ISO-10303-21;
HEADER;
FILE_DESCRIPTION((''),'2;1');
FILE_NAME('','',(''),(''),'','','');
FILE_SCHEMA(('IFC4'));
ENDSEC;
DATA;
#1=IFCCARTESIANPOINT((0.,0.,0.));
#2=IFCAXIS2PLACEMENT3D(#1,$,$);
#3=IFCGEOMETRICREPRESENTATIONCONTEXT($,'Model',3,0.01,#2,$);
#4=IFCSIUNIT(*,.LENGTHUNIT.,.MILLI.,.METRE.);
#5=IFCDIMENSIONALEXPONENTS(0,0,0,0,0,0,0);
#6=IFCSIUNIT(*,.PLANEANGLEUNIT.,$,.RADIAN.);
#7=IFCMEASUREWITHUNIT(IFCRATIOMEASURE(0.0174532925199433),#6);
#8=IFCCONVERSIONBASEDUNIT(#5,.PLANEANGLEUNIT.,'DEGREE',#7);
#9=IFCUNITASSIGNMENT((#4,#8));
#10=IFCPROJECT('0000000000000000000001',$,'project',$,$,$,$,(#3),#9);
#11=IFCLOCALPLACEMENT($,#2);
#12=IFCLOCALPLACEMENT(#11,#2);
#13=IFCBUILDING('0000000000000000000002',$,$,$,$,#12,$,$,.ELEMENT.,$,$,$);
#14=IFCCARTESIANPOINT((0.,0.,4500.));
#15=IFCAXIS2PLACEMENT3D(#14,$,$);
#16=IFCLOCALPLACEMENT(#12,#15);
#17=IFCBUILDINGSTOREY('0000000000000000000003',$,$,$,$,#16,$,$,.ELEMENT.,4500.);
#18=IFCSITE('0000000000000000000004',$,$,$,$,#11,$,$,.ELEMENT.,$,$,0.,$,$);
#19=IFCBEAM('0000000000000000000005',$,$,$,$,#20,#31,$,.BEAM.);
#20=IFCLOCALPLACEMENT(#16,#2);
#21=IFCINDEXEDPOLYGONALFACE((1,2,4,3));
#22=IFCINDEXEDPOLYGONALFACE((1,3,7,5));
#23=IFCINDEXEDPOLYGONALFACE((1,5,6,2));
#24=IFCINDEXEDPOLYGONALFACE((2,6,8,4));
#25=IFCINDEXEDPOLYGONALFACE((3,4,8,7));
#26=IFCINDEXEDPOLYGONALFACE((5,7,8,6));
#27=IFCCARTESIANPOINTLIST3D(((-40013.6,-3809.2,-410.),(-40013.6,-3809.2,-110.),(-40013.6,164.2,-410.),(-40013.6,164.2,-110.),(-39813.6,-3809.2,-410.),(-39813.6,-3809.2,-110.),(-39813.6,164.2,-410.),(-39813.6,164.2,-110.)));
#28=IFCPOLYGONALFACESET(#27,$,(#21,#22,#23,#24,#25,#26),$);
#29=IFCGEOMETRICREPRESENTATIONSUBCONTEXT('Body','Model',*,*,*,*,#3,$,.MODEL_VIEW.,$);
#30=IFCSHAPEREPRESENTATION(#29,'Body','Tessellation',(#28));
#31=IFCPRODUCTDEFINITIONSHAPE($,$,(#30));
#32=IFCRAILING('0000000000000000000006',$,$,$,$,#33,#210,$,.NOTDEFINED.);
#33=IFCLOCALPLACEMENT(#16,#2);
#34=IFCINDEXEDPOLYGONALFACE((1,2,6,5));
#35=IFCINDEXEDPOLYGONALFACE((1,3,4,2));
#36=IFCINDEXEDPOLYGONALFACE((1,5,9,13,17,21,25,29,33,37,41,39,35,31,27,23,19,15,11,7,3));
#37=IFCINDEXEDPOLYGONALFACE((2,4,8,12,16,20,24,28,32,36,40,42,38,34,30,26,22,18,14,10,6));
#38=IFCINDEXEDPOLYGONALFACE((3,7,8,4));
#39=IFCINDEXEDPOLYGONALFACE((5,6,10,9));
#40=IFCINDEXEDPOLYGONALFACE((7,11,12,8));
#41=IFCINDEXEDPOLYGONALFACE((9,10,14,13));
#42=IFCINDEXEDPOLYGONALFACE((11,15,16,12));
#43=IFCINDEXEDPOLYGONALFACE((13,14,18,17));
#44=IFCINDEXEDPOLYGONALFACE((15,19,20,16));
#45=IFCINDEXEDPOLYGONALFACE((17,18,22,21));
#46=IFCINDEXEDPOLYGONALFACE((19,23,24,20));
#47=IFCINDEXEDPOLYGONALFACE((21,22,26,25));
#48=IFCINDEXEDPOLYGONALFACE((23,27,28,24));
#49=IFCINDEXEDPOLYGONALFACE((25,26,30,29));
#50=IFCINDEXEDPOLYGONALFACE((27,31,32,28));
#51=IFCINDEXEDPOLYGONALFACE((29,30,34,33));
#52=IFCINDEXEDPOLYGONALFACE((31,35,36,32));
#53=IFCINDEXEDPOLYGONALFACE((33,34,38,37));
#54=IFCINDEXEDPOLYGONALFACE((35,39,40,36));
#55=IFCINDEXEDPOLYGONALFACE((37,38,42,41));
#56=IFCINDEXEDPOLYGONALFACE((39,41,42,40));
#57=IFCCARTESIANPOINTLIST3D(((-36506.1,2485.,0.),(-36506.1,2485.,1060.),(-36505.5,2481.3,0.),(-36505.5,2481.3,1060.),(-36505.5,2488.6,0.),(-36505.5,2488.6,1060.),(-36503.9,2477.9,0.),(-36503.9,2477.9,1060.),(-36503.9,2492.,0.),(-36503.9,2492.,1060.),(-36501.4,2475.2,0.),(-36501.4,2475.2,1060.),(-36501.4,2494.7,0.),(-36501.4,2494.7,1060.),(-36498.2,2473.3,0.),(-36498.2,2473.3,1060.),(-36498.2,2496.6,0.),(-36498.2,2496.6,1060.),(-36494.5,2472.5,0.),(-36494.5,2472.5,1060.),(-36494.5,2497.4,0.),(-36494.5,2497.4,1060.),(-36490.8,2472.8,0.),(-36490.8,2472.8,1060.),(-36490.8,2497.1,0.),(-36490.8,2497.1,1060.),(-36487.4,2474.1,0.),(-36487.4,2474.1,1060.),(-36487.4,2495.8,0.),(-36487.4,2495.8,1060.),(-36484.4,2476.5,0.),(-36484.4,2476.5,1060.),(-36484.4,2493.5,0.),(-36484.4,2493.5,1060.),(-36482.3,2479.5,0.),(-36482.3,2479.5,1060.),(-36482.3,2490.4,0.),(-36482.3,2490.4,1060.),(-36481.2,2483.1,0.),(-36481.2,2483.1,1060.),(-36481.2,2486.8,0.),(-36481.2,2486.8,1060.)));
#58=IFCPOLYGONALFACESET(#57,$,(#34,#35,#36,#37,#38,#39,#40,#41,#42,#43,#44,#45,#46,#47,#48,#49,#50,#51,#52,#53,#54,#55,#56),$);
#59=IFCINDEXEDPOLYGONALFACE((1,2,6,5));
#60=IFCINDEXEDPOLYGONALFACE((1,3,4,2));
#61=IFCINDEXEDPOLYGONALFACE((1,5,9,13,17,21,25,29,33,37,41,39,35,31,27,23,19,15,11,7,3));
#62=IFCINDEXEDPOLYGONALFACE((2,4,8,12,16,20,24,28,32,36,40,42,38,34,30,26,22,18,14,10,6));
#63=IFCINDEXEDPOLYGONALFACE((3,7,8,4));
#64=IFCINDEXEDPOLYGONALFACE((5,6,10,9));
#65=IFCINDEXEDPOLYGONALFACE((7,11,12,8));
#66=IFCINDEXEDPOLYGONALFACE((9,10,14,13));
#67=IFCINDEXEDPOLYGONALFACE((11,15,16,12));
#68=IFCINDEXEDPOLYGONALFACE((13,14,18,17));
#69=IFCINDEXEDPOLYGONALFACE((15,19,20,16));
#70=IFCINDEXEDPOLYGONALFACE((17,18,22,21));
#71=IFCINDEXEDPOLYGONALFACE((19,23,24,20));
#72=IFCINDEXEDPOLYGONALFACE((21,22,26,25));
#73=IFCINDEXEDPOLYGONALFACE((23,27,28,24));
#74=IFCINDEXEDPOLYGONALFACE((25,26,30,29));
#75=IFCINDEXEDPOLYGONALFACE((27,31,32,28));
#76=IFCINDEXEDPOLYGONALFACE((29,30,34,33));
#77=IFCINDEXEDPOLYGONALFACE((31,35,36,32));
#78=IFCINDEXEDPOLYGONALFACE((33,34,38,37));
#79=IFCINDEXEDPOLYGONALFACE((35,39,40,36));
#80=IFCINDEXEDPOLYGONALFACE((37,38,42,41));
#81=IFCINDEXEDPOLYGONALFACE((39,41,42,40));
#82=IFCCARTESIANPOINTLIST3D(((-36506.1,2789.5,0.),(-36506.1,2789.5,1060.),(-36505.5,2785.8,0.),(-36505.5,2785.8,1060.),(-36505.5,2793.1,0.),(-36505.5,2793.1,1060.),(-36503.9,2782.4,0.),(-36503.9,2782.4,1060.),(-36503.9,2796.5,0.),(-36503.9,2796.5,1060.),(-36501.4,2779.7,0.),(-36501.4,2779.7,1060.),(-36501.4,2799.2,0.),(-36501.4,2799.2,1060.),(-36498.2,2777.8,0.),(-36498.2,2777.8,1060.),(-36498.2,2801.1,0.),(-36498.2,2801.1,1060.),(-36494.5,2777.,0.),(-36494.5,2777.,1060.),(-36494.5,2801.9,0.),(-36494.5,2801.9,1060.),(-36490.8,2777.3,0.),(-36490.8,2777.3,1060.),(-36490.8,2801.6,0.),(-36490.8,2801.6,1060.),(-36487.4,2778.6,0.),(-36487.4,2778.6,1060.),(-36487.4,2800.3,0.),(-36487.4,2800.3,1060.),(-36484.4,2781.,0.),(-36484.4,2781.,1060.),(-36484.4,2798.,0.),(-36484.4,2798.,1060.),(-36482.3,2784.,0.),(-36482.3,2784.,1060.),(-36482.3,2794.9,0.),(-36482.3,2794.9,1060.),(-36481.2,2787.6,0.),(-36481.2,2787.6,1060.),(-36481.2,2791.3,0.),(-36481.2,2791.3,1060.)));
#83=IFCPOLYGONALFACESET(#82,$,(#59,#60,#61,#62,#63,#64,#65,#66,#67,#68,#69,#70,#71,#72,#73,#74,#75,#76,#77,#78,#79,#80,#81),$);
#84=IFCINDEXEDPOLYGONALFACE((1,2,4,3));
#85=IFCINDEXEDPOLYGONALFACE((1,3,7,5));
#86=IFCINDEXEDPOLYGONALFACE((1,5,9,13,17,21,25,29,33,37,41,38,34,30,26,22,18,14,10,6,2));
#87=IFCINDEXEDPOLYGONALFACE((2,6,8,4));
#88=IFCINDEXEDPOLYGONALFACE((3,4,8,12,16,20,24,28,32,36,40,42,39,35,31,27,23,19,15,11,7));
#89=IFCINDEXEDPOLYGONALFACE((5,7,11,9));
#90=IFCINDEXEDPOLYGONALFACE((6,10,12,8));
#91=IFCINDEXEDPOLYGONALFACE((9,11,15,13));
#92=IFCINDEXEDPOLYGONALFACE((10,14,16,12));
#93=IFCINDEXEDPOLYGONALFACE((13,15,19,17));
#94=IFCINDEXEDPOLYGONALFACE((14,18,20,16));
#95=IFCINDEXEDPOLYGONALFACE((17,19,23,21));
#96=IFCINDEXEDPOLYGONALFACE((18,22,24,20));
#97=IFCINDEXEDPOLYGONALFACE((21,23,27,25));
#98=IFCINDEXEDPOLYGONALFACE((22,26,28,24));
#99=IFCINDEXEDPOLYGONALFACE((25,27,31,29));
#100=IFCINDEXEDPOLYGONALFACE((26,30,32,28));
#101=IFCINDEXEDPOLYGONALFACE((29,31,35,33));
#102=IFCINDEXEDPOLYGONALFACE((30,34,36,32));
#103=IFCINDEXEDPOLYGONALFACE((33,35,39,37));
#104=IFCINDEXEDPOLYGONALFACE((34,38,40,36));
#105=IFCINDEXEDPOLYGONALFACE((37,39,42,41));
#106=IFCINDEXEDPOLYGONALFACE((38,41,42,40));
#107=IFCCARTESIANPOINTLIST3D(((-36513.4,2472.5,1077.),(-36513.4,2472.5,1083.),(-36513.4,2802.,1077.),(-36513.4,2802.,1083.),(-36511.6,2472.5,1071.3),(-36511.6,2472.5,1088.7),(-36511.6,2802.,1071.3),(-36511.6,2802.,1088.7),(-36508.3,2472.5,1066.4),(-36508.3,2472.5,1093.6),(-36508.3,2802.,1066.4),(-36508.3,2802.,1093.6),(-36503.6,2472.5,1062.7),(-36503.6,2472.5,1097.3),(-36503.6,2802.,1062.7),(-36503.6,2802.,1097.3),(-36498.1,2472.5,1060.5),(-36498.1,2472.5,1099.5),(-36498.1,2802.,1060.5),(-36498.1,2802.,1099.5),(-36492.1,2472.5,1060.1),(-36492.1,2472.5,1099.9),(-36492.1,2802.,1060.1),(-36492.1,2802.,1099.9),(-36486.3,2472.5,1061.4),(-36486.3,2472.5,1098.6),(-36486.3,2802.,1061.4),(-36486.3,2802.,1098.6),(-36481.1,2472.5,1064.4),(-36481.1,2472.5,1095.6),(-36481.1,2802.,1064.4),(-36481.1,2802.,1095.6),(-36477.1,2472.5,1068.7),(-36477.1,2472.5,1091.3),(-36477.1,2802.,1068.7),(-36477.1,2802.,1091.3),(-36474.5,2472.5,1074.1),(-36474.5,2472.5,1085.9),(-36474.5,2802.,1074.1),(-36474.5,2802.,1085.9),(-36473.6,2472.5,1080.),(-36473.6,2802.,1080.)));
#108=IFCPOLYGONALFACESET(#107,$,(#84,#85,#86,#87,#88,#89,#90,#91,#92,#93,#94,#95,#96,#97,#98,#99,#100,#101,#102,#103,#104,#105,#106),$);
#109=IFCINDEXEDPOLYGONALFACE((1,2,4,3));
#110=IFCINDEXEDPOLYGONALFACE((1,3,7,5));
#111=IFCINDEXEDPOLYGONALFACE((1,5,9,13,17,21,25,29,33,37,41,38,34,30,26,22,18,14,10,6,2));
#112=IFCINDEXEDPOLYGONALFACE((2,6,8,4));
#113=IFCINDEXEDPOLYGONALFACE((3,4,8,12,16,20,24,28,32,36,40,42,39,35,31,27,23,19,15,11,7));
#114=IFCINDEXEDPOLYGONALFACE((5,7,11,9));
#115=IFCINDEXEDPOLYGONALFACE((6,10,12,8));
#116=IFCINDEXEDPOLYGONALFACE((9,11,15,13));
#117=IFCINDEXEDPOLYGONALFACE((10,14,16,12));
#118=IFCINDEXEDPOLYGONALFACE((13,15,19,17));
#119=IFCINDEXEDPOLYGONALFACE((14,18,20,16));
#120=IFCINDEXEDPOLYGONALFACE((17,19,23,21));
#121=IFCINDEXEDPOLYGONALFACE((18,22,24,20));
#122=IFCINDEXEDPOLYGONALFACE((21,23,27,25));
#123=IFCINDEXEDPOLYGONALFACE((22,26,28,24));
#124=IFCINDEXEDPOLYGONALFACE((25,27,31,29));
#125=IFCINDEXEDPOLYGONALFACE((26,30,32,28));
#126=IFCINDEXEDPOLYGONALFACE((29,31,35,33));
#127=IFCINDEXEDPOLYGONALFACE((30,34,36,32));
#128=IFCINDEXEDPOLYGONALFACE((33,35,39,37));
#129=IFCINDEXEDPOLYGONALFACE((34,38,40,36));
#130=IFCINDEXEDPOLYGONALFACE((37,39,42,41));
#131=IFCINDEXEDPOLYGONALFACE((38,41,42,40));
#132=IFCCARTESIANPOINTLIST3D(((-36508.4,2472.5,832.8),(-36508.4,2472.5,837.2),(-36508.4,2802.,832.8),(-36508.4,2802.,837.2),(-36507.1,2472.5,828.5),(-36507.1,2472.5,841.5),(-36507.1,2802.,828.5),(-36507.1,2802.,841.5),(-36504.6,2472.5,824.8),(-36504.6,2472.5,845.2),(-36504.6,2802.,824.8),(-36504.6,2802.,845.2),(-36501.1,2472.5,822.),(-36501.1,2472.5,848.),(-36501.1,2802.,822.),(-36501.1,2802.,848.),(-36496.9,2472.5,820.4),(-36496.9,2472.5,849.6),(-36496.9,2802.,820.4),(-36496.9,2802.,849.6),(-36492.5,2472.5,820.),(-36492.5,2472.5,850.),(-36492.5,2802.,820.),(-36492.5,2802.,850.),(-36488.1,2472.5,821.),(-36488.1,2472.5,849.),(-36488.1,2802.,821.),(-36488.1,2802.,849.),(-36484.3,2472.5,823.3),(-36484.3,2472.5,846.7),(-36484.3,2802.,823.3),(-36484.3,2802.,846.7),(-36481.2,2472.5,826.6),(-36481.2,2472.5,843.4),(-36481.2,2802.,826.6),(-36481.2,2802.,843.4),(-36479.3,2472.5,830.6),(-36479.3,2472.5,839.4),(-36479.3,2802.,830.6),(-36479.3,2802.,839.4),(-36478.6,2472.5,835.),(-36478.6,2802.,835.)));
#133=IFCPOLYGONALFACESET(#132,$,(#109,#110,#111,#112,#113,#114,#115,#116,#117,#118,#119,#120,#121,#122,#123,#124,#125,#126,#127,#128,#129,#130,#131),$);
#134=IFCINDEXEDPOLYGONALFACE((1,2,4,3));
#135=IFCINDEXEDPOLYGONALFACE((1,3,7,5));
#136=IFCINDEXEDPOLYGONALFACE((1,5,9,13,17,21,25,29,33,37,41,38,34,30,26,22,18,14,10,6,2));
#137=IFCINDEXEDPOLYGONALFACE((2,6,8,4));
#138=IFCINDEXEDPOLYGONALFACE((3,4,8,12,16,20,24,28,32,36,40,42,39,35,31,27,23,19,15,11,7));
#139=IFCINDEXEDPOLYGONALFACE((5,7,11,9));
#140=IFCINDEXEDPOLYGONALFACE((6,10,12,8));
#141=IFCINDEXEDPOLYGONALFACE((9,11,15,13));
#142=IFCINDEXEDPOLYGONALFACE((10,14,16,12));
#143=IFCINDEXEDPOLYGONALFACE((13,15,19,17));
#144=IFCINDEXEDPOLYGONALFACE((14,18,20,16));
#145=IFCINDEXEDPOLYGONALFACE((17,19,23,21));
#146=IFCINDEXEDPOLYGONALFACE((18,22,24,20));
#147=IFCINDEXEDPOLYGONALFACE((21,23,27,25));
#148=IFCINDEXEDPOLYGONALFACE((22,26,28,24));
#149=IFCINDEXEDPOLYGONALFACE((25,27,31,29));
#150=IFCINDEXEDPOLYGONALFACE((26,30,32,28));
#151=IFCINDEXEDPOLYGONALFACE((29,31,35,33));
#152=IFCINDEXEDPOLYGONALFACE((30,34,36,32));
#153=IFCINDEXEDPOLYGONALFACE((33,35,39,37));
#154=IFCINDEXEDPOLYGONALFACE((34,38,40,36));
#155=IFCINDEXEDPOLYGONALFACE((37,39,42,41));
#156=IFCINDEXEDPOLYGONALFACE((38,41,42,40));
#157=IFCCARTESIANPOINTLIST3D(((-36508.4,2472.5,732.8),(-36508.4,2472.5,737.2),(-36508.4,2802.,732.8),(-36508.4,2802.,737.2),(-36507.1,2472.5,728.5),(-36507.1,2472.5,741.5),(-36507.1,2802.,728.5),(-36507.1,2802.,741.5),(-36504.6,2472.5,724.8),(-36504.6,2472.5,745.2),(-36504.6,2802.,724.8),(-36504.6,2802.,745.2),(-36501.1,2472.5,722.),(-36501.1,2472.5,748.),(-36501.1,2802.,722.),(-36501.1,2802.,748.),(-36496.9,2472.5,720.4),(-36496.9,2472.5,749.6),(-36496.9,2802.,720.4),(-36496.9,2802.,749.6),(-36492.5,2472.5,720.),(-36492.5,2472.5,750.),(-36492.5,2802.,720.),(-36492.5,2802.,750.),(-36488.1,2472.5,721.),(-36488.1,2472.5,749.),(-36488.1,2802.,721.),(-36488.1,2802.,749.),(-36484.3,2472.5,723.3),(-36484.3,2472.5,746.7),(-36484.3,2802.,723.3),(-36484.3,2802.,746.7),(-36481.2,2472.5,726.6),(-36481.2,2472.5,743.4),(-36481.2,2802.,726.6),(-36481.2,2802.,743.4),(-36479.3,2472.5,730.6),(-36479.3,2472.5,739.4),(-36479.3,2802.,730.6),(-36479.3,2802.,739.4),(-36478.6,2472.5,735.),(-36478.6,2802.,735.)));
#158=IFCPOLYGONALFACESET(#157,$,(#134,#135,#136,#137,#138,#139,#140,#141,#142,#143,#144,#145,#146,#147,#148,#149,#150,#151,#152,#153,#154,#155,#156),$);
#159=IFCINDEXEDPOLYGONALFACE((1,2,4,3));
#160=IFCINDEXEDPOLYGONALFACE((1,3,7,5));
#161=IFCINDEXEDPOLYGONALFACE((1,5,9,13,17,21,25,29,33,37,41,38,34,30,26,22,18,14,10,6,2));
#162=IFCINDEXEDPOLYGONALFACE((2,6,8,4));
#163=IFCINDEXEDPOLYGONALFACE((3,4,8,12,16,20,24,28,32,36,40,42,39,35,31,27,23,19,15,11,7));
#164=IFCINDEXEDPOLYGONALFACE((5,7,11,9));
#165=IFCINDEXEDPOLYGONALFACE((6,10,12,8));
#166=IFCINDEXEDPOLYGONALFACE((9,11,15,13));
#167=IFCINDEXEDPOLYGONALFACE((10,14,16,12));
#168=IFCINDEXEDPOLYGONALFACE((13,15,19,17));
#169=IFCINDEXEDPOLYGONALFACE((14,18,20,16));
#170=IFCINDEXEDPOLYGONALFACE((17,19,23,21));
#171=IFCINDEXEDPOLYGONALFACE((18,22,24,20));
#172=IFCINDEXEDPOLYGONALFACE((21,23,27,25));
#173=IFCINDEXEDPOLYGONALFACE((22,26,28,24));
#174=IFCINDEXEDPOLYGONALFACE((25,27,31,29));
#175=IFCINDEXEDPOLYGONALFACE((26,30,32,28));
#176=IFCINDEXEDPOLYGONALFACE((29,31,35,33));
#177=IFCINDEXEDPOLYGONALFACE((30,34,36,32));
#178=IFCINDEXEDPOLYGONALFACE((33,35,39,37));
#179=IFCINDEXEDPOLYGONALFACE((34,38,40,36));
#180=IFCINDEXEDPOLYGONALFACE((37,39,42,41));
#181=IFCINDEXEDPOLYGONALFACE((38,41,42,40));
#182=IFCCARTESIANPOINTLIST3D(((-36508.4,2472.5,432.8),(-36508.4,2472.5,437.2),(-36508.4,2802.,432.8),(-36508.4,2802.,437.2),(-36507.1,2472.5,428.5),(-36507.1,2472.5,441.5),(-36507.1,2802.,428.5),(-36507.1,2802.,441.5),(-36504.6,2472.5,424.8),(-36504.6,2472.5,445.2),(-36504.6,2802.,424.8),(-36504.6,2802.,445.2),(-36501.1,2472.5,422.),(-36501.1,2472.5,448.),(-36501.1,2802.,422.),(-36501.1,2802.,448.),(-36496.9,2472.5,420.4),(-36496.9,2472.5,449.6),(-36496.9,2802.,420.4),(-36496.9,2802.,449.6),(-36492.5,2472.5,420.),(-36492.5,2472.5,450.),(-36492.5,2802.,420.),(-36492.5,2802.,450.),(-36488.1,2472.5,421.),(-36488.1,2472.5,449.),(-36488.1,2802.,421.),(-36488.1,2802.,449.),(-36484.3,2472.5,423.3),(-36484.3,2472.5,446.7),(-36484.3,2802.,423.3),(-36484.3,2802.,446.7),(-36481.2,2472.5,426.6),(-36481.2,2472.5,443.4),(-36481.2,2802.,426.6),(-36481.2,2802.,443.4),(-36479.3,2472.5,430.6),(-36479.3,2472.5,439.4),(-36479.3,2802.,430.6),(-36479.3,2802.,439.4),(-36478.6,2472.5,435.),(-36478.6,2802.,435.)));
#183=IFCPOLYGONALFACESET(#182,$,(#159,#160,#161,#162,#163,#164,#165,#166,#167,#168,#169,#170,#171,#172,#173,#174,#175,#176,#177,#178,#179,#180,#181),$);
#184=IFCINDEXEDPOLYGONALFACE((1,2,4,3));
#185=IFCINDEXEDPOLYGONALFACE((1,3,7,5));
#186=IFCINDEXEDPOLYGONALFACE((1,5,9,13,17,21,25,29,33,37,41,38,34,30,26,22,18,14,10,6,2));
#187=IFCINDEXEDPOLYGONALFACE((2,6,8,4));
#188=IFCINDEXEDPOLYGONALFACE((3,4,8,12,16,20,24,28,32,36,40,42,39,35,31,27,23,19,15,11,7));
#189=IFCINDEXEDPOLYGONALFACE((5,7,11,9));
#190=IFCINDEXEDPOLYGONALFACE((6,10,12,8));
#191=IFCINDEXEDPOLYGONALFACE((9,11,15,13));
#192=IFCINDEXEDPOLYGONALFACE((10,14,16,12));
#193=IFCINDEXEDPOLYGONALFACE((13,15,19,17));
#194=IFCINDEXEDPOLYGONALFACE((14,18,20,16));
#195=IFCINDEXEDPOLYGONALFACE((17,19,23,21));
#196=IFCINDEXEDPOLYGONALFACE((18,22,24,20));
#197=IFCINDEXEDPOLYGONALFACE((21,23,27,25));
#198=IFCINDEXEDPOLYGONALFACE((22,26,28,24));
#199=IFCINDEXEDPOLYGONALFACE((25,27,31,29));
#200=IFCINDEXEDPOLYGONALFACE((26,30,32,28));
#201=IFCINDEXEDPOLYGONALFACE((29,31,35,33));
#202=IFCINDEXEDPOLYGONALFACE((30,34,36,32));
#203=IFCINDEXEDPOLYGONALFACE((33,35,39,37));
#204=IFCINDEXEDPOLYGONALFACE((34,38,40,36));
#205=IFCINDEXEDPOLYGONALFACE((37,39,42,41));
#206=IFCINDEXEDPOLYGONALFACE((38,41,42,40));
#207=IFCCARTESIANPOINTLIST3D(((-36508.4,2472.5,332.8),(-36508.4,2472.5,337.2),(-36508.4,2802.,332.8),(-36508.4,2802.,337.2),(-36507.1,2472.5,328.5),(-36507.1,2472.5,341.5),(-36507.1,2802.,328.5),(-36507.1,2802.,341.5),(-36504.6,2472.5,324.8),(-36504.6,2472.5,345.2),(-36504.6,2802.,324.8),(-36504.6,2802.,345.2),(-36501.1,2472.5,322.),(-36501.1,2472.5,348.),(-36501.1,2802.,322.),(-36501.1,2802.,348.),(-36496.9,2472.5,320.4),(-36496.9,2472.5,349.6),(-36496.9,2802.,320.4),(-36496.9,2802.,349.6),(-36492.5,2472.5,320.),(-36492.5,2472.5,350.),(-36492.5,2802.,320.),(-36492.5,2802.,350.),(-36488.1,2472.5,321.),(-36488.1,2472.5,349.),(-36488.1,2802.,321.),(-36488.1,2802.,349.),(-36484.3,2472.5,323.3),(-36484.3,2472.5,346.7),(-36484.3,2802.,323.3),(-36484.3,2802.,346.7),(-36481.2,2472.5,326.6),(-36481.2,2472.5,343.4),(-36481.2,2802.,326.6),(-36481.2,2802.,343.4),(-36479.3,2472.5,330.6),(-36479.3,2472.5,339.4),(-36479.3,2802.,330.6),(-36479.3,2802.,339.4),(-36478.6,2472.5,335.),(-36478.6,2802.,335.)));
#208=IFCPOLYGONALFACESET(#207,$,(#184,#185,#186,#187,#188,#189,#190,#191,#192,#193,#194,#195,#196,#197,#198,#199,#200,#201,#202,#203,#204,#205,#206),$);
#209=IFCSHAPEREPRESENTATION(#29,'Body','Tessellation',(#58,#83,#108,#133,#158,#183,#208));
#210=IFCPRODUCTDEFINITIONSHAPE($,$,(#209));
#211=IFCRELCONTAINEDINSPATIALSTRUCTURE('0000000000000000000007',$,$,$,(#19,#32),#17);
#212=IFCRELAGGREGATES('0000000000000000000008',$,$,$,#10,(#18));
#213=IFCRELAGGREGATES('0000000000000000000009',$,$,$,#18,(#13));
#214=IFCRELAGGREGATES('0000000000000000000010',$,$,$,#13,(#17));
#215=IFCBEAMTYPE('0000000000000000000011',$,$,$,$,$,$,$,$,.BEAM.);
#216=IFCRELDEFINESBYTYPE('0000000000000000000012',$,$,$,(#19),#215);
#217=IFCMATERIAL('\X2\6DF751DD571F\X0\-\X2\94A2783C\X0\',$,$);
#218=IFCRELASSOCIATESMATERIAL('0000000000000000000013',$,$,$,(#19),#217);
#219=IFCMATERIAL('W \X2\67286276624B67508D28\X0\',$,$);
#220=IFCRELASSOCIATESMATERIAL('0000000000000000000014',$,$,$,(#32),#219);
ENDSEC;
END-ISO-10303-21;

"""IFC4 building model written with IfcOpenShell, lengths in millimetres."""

from ifc_helpers import new_model, entity, si_unit, converted_unit, frame, frame_2d, origin, origin_2d_with_axis, place, context, subcontext, project, spatial, rectangle, circle, extrude, material, type_object, element, save


model = new_model("IFC4")

# Units and contexts
model_context = context("Model", 3, precision=0.01, world=origin())
body_context = subcontext(model_context, "Body", "Model", "MODEL_VIEW")
ifc_project = project(units=[si_unit("LENGTHUNIT", "METRE", prefix="MILLI"), converted_unit("PLANEANGLEUNIT", "DEGREE", entity("IfcRatioMeasure", 0.0174532925199433), si_unit("PLANEANGLEUNIT", "RADIAN"), dimensions=[0, 0, 0, 0, 0, 0, 0])], contexts=[model_context])

# Site, building, storey
site_placement = place(None, origin())
site = spatial("IfcSite", under=ifc_project, at=site_placement, CompositionType="ELEMENT", RefElevation=0.0)
building_placement = place(site_placement, origin())
building = spatial("IfcBuilding", under=site, at=building_placement, CompositionType="ELEMENT")
storey_placement = place(building_placement, frame((0.0, 0.0, 4500.0)))
storey = spatial("IfcBuildingStorey", under=building, at=storey_placement, CompositionType="ELEMENT", Elevation=4500.0)

# Beam
ifc_material_1 = material(Name="混凝土-钢砼")
beam_type = type_object("IfcBeamType", PredefinedType="BEAM")
beam_placement = place(storey_placement, frame((-39913.6, 277.5, -110.0), z_axis=(0.0, 0.0, 1.0), x_axis=(0.0, -1.0, 0.0)))
element("IfcBeam", 1, at=beam_placement, inside=storey, type_object=beam_type, material=ifc_material_1, PredefinedType="BEAM", context=body_context, shape_type="SweptSolid", body=[
    extrude(rectangle(XDim=300.0, YDim=200.0, at=frame_2d((0.0, 0.0), x_axis=(1.0, 0.0))), frame((113.3, 0.0, -150.0), z_axis=(1.0, 0.0, 0.0), x_axis=(0.0, 0.0, -1.0)), (0.0, 0.0, 1.0), 3973.4),
])

# Railing
ifc_material_2 = material(Name="W 木扶手材质")
railing_placement = place(storey_placement, frame((-36515.2, 2470.9, 0.0)))
element("IfcRailing", 2, at=railing_placement, inside=storey, material=ifc_material_2, PredefinedType="NOTDEFINED", context=body_context, shape_type="SweptSolid", body=[
    extrude(circle(Radius=12.5, at=origin_2d_with_axis()), frame((21.6, 14.1, 0.0), z_axis=(0.0, 0.0, 1.0), x_axis=(-1.0, 0.0, 0.0)), (0.0, 0.0, 1.0), 1060.0),
    extrude(circle(Radius=12.5, at=origin_2d_with_axis()), frame((21.6, 318.6, 0.0), z_axis=(0.0, 0.0, 1.0), x_axis=(-1.0, 0.0, 0.0)), (0.0, 0.0, 1.0), 1060.0),
    extrude(circle(Radius=20.0, at=origin_2d_with_axis()), frame((21.6, 1.6, 1080.0), z_axis=(0.0, 1.0, 0.0), x_axis=(1.0, 0.0, 0.0)), (0.0, 0.0, 1.0), 329.5),
    extrude(circle(Radius=15.0, at=origin_2d_with_axis()), frame((21.6, 1.6, 835.0), z_axis=(0.0, 1.0, 0.0), x_axis=(1.0, 0.0, 0.0)), (0.0, 0.0, 1.0), 329.5),
    extrude(circle(Radius=15.0, at=origin_2d_with_axis()), frame((21.6, 1.6, 735.0), z_axis=(0.0, 1.0, 0.0), x_axis=(1.0, 0.0, 0.0)), (0.0, 0.0, 1.0), 329.5),
    extrude(circle(Radius=15.0, at=origin_2d_with_axis()), frame((21.6, 1.6, 435.0), z_axis=(0.0, 1.0, 0.0), x_axis=(1.0, 0.0, 0.0)), (0.0, 0.0, 1.0), 329.5),
    extrude(circle(Radius=15.0, at=origin_2d_with_axis()), frame((21.6, 1.6, 335.0), z_axis=(0.0, 1.0, 0.0), x_axis=(1.0, 0.0, 0.0)), (0.0, 0.0, 1.0), 329.5),
])

save(model, "model.ifc")
